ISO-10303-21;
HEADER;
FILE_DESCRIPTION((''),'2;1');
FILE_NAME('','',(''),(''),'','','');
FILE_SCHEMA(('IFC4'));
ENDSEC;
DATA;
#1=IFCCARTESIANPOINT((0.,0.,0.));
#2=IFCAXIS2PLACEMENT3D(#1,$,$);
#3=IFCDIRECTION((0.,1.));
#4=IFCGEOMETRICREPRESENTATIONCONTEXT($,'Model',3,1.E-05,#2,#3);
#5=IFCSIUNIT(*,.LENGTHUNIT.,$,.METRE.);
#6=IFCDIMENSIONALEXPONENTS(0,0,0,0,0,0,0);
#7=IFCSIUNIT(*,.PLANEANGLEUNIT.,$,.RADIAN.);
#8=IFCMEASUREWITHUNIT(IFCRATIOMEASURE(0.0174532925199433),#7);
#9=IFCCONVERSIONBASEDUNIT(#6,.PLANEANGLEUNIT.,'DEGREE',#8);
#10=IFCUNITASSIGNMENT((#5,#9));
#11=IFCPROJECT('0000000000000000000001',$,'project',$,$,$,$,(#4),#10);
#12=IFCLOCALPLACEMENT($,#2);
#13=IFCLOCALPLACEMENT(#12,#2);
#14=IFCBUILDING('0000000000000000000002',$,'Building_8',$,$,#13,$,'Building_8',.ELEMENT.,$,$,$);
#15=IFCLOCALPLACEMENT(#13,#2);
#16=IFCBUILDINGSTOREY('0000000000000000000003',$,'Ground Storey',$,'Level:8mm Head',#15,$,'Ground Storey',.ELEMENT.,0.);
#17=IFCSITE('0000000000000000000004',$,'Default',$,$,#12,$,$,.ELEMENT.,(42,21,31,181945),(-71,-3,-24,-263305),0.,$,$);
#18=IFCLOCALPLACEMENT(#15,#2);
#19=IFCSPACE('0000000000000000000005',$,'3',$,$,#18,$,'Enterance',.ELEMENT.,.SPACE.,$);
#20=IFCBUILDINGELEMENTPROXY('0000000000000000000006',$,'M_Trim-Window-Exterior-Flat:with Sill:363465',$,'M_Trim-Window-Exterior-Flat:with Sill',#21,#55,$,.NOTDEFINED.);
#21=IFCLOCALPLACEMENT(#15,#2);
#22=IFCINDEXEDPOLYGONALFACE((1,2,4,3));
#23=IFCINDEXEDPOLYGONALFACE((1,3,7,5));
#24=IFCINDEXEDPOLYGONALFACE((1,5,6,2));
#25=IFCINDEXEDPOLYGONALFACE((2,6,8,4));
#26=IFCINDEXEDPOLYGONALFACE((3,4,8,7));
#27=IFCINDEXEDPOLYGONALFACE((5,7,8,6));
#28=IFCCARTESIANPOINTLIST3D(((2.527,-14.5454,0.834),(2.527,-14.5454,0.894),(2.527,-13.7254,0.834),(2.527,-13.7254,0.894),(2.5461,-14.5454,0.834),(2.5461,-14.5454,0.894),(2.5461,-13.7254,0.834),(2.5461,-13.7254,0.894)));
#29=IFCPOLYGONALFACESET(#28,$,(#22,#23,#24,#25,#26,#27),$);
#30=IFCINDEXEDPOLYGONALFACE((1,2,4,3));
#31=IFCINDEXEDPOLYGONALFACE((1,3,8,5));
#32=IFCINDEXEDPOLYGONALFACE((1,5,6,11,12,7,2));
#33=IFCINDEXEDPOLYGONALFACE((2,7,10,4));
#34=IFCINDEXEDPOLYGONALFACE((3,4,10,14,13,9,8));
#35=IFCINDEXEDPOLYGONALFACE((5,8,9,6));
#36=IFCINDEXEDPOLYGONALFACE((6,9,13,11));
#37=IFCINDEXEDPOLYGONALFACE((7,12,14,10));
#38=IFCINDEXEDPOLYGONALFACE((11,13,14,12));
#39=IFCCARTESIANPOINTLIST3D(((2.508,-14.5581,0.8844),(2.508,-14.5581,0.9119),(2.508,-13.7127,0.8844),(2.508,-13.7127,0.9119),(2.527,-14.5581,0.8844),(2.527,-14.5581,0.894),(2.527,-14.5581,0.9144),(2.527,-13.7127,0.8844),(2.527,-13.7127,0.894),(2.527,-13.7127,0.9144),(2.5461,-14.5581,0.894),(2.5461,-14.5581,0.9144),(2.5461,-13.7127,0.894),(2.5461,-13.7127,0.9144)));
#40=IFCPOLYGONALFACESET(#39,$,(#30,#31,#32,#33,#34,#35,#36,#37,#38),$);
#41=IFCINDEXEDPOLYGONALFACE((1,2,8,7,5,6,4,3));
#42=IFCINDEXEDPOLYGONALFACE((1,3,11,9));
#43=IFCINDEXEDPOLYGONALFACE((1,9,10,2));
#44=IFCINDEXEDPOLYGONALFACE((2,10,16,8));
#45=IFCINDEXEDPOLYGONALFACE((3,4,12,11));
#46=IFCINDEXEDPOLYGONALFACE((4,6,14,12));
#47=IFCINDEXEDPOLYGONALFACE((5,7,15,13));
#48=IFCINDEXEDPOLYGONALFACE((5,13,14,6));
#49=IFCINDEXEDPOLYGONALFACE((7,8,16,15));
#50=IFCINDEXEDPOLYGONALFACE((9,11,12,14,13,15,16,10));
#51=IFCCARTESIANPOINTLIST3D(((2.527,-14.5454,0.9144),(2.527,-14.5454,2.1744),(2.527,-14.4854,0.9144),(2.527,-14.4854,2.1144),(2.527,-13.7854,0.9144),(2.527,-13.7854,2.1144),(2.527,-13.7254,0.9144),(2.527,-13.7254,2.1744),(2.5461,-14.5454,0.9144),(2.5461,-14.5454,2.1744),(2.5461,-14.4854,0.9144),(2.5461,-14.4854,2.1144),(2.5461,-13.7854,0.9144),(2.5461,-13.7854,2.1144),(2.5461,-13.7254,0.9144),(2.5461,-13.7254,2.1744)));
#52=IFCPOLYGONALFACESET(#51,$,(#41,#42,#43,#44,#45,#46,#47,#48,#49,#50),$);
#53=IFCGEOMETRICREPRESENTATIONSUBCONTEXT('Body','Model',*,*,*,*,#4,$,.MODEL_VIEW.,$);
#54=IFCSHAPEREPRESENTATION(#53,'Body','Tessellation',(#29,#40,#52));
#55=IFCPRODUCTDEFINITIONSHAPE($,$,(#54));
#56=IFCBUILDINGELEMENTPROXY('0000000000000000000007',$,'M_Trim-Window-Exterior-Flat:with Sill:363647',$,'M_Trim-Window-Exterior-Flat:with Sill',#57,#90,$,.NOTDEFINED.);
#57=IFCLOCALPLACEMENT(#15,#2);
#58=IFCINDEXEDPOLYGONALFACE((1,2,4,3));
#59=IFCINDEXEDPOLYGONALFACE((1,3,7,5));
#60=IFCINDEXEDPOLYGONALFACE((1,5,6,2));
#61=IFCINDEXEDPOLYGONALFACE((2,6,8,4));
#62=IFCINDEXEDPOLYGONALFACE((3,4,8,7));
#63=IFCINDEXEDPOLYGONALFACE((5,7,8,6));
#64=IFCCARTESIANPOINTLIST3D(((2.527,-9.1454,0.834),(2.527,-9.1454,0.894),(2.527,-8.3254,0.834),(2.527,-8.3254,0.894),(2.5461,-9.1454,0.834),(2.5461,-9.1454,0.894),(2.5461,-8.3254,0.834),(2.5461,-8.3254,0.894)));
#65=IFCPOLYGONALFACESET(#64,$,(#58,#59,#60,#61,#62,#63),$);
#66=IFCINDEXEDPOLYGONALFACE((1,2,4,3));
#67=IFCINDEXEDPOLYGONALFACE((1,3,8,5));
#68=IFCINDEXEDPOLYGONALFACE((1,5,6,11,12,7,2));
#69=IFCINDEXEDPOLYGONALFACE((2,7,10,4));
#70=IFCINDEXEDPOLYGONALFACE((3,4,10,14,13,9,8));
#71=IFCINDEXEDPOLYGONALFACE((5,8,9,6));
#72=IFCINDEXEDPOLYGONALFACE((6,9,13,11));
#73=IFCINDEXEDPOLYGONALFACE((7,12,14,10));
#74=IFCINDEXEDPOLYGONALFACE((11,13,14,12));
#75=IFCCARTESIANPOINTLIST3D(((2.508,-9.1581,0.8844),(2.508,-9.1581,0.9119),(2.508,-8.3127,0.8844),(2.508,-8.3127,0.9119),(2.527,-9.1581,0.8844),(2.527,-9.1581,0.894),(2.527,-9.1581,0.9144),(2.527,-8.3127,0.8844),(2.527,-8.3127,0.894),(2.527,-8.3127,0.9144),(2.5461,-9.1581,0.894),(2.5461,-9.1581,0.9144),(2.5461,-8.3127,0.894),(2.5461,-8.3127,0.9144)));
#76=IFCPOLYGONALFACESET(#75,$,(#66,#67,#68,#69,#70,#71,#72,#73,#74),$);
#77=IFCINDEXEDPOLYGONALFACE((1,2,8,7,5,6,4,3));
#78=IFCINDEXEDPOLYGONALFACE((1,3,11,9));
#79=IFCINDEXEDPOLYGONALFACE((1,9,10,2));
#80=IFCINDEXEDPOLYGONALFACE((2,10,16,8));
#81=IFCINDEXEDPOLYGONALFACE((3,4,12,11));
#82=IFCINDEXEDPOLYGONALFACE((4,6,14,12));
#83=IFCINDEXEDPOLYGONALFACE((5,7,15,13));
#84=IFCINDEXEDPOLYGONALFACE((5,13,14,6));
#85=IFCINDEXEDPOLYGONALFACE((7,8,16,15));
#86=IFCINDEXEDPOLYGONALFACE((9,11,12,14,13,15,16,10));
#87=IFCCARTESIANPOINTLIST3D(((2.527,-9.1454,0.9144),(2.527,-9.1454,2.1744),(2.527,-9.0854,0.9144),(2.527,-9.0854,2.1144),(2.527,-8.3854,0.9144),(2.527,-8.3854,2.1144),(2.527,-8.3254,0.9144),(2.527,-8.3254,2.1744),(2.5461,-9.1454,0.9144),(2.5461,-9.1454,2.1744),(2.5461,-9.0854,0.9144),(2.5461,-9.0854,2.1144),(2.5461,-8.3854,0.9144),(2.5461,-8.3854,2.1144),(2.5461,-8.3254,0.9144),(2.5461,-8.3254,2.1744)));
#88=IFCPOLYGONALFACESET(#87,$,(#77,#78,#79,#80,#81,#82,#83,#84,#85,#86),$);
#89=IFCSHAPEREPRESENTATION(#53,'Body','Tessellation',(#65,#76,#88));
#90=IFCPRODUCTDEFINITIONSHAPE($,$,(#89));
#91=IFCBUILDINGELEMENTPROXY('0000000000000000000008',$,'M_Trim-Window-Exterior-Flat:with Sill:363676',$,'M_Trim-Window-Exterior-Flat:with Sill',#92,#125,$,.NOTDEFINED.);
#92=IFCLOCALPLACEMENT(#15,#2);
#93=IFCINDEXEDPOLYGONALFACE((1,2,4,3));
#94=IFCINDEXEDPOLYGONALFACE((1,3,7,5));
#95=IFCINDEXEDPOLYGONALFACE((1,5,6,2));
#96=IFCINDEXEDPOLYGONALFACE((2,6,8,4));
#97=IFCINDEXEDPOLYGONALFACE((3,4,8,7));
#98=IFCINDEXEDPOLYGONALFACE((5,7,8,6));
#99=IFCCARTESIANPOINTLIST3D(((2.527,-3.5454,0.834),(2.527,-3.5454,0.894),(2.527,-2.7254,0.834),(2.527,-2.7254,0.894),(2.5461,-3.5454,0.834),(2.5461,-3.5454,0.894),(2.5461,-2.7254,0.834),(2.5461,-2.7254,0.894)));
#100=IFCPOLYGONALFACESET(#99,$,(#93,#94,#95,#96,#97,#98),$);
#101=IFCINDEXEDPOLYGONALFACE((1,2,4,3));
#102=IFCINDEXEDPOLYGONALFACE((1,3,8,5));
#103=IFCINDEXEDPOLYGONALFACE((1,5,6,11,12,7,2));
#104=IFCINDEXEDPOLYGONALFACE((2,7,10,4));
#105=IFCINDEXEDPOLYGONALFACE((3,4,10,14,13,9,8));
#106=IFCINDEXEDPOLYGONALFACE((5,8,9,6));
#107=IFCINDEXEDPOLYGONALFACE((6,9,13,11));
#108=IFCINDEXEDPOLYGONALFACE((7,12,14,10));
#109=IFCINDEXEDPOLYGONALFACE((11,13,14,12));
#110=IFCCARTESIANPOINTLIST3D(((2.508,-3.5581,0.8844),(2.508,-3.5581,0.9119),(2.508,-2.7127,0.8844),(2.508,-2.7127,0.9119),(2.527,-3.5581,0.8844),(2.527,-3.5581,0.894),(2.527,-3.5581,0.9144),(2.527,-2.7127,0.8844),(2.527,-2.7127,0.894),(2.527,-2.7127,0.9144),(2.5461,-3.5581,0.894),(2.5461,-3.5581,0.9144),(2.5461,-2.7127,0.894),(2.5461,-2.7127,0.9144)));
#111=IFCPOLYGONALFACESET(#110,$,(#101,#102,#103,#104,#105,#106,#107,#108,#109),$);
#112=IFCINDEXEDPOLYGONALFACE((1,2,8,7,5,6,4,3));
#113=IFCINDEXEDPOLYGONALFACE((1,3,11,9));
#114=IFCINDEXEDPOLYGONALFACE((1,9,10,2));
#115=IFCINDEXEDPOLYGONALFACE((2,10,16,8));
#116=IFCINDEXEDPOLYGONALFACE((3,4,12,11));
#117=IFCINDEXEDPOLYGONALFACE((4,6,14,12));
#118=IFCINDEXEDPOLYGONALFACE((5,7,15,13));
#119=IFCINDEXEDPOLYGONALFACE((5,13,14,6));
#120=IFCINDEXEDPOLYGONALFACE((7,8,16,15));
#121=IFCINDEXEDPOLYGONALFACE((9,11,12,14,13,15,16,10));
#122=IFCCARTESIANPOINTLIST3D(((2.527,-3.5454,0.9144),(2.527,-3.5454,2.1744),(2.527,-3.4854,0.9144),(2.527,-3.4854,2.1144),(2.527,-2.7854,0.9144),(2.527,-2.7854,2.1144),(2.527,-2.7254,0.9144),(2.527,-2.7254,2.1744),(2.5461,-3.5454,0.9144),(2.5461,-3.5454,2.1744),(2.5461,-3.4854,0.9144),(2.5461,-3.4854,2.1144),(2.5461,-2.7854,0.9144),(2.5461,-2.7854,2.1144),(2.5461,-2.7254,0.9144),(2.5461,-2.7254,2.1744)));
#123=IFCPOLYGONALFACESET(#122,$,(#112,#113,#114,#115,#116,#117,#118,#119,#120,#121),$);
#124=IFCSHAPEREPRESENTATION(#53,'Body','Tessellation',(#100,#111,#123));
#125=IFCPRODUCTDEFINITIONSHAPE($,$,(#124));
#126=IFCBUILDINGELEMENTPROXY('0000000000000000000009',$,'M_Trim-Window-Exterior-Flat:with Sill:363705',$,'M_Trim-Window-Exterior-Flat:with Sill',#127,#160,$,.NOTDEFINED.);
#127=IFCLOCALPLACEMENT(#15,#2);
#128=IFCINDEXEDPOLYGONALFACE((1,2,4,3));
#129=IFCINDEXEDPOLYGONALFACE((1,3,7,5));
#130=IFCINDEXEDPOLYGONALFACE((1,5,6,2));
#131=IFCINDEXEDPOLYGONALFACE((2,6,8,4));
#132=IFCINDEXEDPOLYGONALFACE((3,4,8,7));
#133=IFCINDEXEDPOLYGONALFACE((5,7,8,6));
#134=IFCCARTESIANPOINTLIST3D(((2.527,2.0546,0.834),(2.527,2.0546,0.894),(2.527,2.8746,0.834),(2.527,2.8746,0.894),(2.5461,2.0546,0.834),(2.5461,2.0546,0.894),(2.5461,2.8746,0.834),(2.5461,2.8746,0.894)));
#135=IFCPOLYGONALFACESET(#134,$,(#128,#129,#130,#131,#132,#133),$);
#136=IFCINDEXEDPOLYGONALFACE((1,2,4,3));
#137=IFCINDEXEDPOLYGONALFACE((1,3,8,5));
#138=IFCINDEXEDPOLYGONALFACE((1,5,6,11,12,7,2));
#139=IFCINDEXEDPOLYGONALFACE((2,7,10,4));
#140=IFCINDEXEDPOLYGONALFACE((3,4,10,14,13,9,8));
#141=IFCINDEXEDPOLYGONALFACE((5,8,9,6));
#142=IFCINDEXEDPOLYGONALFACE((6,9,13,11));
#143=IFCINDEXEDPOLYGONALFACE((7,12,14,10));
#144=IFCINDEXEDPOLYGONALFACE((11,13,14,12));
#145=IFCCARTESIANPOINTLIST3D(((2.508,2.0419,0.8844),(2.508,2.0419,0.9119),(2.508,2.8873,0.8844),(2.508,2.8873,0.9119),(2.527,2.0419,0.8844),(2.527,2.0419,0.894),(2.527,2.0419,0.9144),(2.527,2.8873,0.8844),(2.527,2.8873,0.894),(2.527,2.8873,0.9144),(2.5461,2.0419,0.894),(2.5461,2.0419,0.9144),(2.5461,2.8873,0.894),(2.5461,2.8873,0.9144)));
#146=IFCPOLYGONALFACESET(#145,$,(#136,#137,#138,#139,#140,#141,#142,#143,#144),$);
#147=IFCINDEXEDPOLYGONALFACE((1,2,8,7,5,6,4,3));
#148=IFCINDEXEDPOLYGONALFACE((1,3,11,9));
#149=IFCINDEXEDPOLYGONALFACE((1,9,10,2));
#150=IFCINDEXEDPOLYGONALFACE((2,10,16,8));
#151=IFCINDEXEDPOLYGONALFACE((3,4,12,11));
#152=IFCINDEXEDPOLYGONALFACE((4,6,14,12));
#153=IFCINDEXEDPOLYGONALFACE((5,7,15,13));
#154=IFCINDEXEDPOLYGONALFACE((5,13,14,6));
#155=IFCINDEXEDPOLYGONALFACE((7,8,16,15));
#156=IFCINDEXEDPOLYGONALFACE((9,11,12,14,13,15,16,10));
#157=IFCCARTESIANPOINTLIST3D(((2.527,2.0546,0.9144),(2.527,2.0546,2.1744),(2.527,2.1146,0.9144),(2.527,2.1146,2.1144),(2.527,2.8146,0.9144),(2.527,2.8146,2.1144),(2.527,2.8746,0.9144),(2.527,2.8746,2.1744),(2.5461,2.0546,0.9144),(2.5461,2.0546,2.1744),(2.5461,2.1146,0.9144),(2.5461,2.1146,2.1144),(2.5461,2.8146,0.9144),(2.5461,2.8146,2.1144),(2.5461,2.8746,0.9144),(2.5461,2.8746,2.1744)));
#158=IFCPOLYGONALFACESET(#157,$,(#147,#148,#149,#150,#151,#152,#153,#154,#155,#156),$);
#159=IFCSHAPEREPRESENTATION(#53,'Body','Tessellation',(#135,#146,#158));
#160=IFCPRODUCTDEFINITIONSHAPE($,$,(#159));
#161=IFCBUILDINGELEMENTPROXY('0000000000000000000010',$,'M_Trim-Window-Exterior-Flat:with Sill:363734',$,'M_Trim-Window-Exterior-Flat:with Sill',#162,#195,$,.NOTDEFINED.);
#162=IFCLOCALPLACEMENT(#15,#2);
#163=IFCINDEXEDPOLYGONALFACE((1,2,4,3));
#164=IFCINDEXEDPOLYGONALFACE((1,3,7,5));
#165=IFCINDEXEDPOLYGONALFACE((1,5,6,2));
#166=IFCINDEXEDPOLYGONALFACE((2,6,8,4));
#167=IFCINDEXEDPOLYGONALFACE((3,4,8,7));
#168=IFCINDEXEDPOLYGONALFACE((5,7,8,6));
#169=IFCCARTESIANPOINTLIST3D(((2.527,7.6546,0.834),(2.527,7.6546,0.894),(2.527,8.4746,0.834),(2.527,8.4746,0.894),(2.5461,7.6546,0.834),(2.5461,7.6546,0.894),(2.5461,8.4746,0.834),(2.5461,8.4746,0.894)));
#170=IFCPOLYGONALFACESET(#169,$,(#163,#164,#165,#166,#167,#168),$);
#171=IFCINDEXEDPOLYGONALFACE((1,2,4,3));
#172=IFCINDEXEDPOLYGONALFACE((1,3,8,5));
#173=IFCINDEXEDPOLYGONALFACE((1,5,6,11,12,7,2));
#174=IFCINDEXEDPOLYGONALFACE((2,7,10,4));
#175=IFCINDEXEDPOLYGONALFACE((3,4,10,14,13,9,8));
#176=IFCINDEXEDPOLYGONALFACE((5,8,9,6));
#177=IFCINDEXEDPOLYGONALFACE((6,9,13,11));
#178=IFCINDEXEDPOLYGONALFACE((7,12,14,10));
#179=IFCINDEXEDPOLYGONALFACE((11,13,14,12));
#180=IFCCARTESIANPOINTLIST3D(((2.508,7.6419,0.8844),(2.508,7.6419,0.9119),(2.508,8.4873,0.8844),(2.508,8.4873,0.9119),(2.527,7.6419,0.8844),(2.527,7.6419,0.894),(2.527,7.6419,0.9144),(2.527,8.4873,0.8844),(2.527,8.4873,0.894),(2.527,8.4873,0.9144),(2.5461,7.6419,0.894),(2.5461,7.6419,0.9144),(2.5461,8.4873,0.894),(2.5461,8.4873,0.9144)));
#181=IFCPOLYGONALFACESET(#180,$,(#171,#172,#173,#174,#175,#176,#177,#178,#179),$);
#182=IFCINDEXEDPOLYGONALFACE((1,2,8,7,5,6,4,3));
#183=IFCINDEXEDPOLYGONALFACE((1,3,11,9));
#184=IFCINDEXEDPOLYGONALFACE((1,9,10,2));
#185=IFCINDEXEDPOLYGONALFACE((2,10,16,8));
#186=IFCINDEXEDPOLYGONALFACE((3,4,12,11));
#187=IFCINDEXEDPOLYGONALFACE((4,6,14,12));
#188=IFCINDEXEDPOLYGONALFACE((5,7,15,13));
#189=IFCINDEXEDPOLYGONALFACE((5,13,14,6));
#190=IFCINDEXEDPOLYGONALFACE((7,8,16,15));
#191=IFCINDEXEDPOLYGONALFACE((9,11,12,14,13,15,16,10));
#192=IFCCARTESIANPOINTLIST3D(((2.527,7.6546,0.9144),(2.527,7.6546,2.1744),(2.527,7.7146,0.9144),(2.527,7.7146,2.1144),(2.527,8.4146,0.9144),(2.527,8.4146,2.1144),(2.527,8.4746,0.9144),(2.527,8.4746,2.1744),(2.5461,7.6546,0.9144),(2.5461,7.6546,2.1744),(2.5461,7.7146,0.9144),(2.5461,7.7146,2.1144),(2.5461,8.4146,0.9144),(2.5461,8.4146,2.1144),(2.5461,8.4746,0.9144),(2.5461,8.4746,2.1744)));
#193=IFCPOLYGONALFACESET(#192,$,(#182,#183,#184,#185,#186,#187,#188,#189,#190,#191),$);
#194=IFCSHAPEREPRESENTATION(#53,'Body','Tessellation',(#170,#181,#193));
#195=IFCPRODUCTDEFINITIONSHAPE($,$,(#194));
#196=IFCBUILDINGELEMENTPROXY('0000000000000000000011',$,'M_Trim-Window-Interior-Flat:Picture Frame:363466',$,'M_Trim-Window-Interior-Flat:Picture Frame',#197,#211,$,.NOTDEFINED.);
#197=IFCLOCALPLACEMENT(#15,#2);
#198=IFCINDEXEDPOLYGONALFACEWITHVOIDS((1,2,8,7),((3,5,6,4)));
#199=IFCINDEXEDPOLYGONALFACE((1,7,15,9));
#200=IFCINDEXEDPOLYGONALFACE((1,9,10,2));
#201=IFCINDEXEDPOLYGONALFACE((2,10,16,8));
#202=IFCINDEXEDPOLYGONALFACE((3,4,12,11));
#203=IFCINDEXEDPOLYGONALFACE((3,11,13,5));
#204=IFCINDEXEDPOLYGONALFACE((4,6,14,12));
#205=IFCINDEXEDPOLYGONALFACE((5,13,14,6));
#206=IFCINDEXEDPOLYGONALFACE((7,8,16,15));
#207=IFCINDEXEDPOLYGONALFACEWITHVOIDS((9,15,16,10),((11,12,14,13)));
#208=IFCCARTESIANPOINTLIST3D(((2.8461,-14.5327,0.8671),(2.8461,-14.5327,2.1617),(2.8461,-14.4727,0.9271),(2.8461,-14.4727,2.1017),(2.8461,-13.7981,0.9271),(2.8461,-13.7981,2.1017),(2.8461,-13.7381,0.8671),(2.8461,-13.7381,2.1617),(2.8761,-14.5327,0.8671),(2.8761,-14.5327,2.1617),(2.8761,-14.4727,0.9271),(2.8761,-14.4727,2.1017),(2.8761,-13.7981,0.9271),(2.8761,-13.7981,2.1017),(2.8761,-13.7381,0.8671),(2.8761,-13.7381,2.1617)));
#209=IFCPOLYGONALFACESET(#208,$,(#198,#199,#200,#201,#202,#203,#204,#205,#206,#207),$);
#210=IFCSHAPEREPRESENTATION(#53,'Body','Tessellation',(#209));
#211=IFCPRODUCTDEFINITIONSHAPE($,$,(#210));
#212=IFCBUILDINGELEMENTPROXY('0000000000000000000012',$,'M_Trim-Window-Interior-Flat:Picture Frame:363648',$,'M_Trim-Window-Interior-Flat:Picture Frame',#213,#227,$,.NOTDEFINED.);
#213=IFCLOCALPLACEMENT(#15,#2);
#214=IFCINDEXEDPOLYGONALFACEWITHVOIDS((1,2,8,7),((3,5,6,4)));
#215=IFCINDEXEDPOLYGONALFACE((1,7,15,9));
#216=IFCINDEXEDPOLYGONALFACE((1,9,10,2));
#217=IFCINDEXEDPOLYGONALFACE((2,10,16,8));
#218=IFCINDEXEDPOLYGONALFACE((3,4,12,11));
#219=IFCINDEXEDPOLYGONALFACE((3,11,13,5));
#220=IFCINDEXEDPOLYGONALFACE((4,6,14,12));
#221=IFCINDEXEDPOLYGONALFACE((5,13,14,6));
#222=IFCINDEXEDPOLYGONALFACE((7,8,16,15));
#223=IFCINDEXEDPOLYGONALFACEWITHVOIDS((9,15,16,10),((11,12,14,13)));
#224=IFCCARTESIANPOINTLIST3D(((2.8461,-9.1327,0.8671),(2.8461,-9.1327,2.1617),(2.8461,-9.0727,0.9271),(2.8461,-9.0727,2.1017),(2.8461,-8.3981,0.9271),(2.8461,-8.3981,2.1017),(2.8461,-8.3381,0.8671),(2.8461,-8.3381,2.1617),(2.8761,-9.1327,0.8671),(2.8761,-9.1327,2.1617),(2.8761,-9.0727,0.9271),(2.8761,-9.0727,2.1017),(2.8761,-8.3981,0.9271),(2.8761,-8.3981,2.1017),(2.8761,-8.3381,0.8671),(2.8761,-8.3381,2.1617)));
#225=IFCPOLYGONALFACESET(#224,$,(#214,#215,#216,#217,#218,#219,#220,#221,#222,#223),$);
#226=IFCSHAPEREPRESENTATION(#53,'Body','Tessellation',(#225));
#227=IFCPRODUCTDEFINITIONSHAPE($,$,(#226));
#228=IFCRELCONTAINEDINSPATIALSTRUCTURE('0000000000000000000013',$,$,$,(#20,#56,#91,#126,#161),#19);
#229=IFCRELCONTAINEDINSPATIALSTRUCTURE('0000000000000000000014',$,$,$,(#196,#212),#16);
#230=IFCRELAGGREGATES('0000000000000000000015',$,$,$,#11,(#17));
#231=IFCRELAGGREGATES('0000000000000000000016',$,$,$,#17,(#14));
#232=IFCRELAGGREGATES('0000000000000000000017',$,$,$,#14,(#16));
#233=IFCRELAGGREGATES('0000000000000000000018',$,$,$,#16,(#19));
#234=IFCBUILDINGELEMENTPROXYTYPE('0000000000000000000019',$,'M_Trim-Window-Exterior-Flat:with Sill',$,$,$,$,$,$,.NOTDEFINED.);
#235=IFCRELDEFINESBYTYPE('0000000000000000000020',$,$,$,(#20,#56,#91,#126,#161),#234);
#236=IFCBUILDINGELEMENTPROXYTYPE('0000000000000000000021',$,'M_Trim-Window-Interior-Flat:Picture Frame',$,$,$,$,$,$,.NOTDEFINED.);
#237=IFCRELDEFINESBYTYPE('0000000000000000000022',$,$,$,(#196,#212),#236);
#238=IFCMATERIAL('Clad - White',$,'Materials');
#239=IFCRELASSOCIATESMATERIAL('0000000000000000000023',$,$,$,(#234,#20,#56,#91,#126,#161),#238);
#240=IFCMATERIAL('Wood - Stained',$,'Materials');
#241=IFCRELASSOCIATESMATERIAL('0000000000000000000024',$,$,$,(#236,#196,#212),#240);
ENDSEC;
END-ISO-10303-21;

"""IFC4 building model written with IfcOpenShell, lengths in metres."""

from ifc_helpers import new_model, entity, si_unit, converted_unit, direction, frame, origin, place, context, subcontext, project, spatial, indexed_curve, outline, extrude, source, transform, mapped, material, type_object, type_shapes, element, save


model = new_model("IFC4")

# Units and contexts
model_context = context("Model", 3, precision=1e-05, world=origin(), true_north=direction((0.0, 1.0)))
body_context = subcontext(model_context, "Body", "Model", "MODEL_VIEW")
ifc_project = project(units=[si_unit("LENGTHUNIT", "METRE"), converted_unit("PLANEANGLEUNIT", "DEGREE", entity("IfcRatioMeasure", 0.0174532925199433), si_unit("PLANEANGLEUNIT", "RADIAN"), dimensions=[0, 0, 0, 0, 0, 0, 0])], contexts=[model_context])

# Site, building, storey
site_placement = place(None, origin())
site = spatial("IfcSite", under=ifc_project, at=site_placement, Name="Default", CompositionType="ELEMENT", RefLatitude=(42, 21, 31, 181945), RefLongitude=(-71, -3, -24, -263305), RefElevation=0.0)
building_placement = place(site_placement, origin())
building = spatial("IfcBuilding", under=site, at=building_placement, Name="Building_8", LongName="Building_8", CompositionType="ELEMENT")
storey_placement = place(building_placement, origin())
storey = spatial("IfcBuildingStorey", under=building, at=storey_placement, Name="Ground Storey", ObjectType="Level:8mm Head", LongName="Ground Storey", CompositionType="ELEMENT", Elevation=0.0)

# Shared definitions
ifc_material_1 = material(Name="Clad - White", Category="Materials")
ifc_material_2 = material(Name="Wood - Stained", Category="Materials")

# Shared definitions
space_placement = place(storey_placement, origin())
space = spatial("IfcSpace", under=storey, at=space_placement, Name="3", LongName="Enterance", CompositionType="ELEMENT", PredefinedType="SPACE")

# Building element proxies
building_element_proxy_type_1 = type_object("IfcBuildingElementProxyType", Name="M_Trim-Window-Exterior-Flat:with Sill", PredefinedType="NOTDEFINED", material=ifc_material_1)
shared_shape_1 = source(origin(), body_context, "Body", "SweptSolid", [
    extrude(outline(indexed_curve([(-0.41, -0.03), (0.41, -0.03), (0.41, 0.03), (-0.41, 0.03), (-0.41, -0.03)], self_intersect=False)), frame((0.0, -1.2504, 0.0), z_axis=(0.0, 0.0, 1.0), x_axis=(-1.0, 0.0, 0.0)), (0.0, 0.0, 1.0), 0.0191),
    extrude(outline(indexed_curve([(-0.019, -0.0152), (0.0, -0.0152), (0.0, -0.0057), (0.019, -0.0057), (0.019, 0.0148), (0.0, 0.0148), (-0.019, 0.0123), (-0.019, -0.0152)], self_intersect=False)), frame((-0.4227, -1.2148, 0.019), z_axis=(1.0, 0.0, 0.0), x_axis=(0.0, 0.0, -1.0)), (0.0, 0.0, 1.0), 0.8454),
    extrude(outline(indexed_curve([(-0.645, -0.41), (0.615, -0.41), (0.615, -0.35), (-0.585, -0.35), (-0.585, 0.35), (0.615, 0.35), (0.615, 0.41), (-0.645, 0.41), (-0.645, -0.41)], self_intersect=False)), frame((0.0, -0.585, 0.0), z_axis=(0.0, 0.0, 1.0), x_axis=(0.0, -1.0, 0.0)), (0.0, 0.0, 1.0), 0.0191),
])
type_shapes(building_element_proxy_type_1, [shared_shape_1])
for number, where, z_axis, x_axis, name in (
    (1, (2.5461, -14.1354, 2.1144), (-1.0, 0.0, 0.0), (0.0, -1.0, 0.0), "M_Trim-Window-Exterior-Flat:with Sill:363465"),
    (2, (2.5461, -8.7354, 2.1144), (-1.0, 0.0, 0.0), (0.0, -1.0, 0.0), "M_Trim-Window-Exterior-Flat:with Sill:363647"),
    (3, (2.5461, -3.1354, 2.1144), (-1.0, 0.0, 0.0), (0.0, -1.0, 0.0), "M_Trim-Window-Exterior-Flat:with Sill:363676"),
    (4, (2.5461, 2.4646, 2.1144), (-1.0, 0.0, 0.0), (0.0, -1.0, 0.0), "M_Trim-Window-Exterior-Flat:with Sill:363705"),
    (5, (2.5461, 8.0646, 2.1144), (-1.0, 0.0, 0.0), (0.0, -1.0, 0.0), "M_Trim-Window-Exterior-Flat:with Sill:363734"),
):
    element("IfcBuildingElementProxy", number, at=place(space_placement, frame(where, z_axis=z_axis, x_axis=x_axis)), inside=space, type_object=building_element_proxy_type_1, material=ifc_material_1, Name=name, ObjectType="M_Trim-Window-Exterior-Flat:with Sill", PredefinedType="NOTDEFINED", context=body_context, shape_type="MappedRepresentation", body=[
        mapped(shared_shape_1, transform((0.0, 0.0, 0.0), scale=1.0)),
    ])
building_element_proxy_type_2 = type_object("IfcBuildingElementProxyType", Name="M_Trim-Window-Interior-Flat:Picture Frame", PredefinedType="NOTDEFINED", material=ifc_material_2)
shared_shape_2 = source(origin(), body_context, "Body", "SweptSolid", [
    extrude(outline(indexed_curve([(-0.3973, -0.6473), (0.3973, -0.6473), (0.3973, 0.6473), (-0.3973, 0.6473), (-0.3973, -0.6473)], self_intersect=False), holes=[indexed_curve([(-0.3373, -0.5873), (-0.3373, 0.5873), (0.3373, 0.5873), (0.3373, -0.5873), (-0.3373, -0.5873)], self_intersect=False)]), frame((0.0, -0.6, 0.0), z_axis=(0.0, 0.0, 1.0), x_axis=(-1.0, 0.0, 0.0)), (0.0, 0.0, 1.0), 0.03),
])
type_shapes(building_element_proxy_type_2, [shared_shape_2])
for number, where, z_axis, x_axis, name in (
    (6, (2.8461, -14.1354, 2.1144), (1.0, 0.0, 0.0), (0.0, 1.0, 0.0), "M_Trim-Window-Interior-Flat:Picture Frame:363466"),
    (7, (2.8461, -8.7354, 2.1144), (1.0, 0.0, 0.0), (0.0, 1.0, 0.0), "M_Trim-Window-Interior-Flat:Picture Frame:363648"),
):
    element("IfcBuildingElementProxy", number, at=place(storey_placement, frame(where, z_axis=z_axis, x_axis=x_axis)), inside=storey, type_object=building_element_proxy_type_2, material=ifc_material_2, Name=name, ObjectType="M_Trim-Window-Interior-Flat:Picture Frame", PredefinedType="NOTDEFINED", context=body_context, shape_type="MappedRepresentation", body=[
        mapped(shared_shape_2, transform((0.0, 0.0, 0.0), scale=1.0)),
    ])

save(model, "model.ifc")
